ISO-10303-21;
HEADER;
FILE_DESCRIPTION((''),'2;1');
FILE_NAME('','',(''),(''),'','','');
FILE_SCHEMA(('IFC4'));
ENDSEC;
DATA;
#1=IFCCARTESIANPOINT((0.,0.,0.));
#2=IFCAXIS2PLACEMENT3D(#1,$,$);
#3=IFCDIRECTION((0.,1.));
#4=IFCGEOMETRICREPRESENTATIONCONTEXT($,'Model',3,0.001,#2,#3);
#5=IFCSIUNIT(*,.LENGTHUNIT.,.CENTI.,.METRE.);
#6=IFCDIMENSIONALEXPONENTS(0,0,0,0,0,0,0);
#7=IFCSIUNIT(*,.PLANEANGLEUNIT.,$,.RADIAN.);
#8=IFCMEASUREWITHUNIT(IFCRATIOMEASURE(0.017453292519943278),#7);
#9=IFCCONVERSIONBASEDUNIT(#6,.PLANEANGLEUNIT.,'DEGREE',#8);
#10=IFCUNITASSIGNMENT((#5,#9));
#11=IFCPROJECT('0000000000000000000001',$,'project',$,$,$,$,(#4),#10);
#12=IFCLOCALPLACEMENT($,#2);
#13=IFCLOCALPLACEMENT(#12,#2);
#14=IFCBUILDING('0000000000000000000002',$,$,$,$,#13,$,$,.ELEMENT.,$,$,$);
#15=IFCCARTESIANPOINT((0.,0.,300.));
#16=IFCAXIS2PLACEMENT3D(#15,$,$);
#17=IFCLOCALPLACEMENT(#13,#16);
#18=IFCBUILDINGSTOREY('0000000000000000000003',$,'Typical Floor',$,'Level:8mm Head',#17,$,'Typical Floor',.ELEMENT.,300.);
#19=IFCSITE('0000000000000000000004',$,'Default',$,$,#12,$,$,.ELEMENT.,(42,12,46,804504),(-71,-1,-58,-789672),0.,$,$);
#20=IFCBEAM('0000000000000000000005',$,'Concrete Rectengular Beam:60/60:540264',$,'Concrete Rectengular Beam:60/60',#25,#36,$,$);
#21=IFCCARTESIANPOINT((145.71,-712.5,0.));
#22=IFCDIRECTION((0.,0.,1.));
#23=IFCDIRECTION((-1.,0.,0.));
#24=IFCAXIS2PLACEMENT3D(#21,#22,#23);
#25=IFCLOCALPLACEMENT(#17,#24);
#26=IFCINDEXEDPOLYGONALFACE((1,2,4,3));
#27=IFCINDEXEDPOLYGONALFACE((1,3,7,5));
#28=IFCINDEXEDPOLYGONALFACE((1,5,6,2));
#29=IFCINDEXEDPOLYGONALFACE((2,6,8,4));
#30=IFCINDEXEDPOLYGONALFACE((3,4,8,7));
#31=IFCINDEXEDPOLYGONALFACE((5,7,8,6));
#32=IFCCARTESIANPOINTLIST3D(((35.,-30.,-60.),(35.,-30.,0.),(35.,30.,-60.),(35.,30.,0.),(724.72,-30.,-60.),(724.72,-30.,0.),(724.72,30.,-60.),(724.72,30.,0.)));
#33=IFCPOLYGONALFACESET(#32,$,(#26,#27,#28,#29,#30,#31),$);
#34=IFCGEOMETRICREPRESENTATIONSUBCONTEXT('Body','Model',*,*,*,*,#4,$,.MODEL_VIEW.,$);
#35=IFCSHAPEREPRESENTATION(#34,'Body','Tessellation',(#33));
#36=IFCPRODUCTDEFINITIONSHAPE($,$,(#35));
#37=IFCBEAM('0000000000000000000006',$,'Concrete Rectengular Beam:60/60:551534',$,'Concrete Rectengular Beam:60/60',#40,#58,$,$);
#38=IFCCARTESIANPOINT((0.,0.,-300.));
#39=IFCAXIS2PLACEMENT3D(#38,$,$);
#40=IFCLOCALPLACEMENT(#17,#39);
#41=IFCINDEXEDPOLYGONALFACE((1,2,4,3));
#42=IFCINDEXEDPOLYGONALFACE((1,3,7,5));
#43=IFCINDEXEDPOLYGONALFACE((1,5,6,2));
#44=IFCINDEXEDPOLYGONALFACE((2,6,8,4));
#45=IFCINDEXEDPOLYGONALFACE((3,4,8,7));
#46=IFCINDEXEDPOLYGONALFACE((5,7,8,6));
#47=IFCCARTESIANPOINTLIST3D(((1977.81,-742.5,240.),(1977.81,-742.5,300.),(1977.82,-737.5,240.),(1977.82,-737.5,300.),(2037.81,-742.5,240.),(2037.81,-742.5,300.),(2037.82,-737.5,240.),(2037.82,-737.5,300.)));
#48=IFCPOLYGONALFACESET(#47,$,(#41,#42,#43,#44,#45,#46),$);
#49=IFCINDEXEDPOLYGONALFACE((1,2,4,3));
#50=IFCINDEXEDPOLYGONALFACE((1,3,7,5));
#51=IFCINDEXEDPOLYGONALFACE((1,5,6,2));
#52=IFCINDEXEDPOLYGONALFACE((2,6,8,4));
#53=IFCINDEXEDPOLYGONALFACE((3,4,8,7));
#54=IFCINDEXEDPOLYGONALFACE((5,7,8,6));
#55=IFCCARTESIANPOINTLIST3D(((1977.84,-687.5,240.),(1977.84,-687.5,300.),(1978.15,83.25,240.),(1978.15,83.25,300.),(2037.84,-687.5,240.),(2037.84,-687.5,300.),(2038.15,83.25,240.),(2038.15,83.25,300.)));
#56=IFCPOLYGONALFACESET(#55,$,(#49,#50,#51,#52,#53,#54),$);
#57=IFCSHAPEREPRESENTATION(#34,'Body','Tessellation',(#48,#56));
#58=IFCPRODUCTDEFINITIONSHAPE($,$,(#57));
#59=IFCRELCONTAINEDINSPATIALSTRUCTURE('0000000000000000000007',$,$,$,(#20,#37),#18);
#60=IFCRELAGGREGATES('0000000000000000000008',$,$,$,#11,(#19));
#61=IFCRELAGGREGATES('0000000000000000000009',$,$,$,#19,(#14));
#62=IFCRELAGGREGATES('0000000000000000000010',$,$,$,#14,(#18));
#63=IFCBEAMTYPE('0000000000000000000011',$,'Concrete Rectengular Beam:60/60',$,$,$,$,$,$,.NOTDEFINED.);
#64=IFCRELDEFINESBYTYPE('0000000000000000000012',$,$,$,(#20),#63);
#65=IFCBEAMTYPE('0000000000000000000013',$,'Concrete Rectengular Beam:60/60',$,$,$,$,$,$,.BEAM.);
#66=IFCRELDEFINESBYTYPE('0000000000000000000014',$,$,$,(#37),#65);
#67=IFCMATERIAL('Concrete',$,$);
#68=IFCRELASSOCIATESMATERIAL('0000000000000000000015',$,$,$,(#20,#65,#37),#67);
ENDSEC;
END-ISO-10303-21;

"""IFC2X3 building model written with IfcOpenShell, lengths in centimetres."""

from ifc_helpers import new_model, entity, si_unit, converted_unit, direction, frame, frame_2d, origin, place, context, subcontext, project, spatial, rectangle, extrude, clip, halfspace, source, transform, mapped, material, type_object, type_shapes, element, save


model = new_model("IFC2X3")

# Units and contexts
model_context = context("Model", 3, precision=0.001, world=origin(), true_north=direction((0.0, 1.0)))
body_context = subcontext(model_context, "Body", "Model", "MODEL_VIEW")
ifc_project = project(units=[si_unit("LENGTHUNIT", "METRE", prefix="CENTI"), converted_unit("PLANEANGLEUNIT", "DEGREE", entity("IfcRatioMeasure", 0.017453292519943278), si_unit("PLANEANGLEUNIT", "RADIAN"), dimensions=[0, 0, 0, 0, 0, 0, 0])], contexts=[model_context])

# Site, building, storey
site_placement = place(None, origin())
site = spatial("IfcSite", under=ifc_project, at=site_placement, Name="Default", CompositionType="ELEMENT", RefLatitude=(42, 12, 46, 804504), RefLongitude=(-71, -1, -58, -789672), RefElevation=0.0)
building_placement = place(site_placement, origin())
building = spatial("IfcBuilding", under=site, at=building_placement, CompositionType="ELEMENT")
storey_placement = place(building_placement, frame((0.0, 0.0, 300.0)))
storey = spatial("IfcBuildingStorey", under=building, at=storey_placement, Name="Typical Floor", ObjectType="Level:8mm Head", LongName="Typical Floor", CompositionType="ELEMENT", Elevation=300.0)

# Beams
ifc_material = material(Name="Concrete")
beam_type_1 = type_object("IfcBeamType", Name="Concrete Rectengular Beam:60/60", PredefinedType="NOTDEFINED")
beam_1_placement = place(storey_placement, frame((145.71, -712.5, 0.0), z_axis=(0.0, 0.0, 1.0), x_axis=(-1.0, 0.0, 0.0)))
element("IfcBeam", 1, at=beam_1_placement, inside=storey, type_object=beam_type_1, material=ifc_material, Name="Concrete Rectengular Beam:60/60:540264", ObjectType="Concrete Rectengular Beam:60/60", context=body_context, shape_type="SweptSolid", body=[
    extrude(rectangle(XDim=60.0, YDim=60.0, at=frame_2d((0.0, 0.0), x_axis=(1.0, 0.0))), frame((35.0, 0.0, -30.0), z_axis=(1.0, 0.0, 0.0), x_axis=(0.0, 0.0, -1.0)), (0.0, 0.0, 1.0), 689.72),
])
beam_type_2 = type_object("IfcBeamType", Name="Concrete Rectengular Beam:60/60", PredefinedType="BEAM", material=ifc_material)
shared_shape = source(origin(), body_context, "Body", "SweptSolid", [
    clip(clip(extrude(rectangle(XDim=60.0, YDim=60.0, at=frame_2d((0.0, 0.0), x_axis=(0.0, 1.0))), frame((2007.82, -737.49, 270.0), z_axis=(-0.000408, -1.0, 0.0), x_axis=(-1.0, 0.000408, 0.0)), (0.0, 0.0, 1.0), 5.02), halfspace(frame((2040.22, -742.5, 300.0), z_axis=(0.0, -1.0, 0.0), x_axis=(-1.0, 0.0, 0.0)), False)), halfspace(frame((1977.83, -737.5, 300.0), z_axis=(0.0, 1.0, 0.0), x_axis=(0.0, 0.0, -1.0)), False)),
    clip(clip(extrude(rectangle(XDim=60.0, YDim=60.0, at=frame_2d((0.0, 0.0), x_axis=(0.0, 1.0))), frame((2008.15, 83.26, 270.0), z_axis=(-0.000408, -1.0, 0.0), x_axis=(-1.0, 0.000408, 0.0)), (0.0, 0.0, 1.0), 770.78), halfspace(frame((2037.83, -687.5, 300.0), z_axis=(0.0, -1.0, 0.0), x_axis=(0.0, 0.0, -1.0)), False)), halfspace(frame((1976.89, 83.25, 270.0), z_axis=(0.0, 1.0, 0.0), x_axis=(0.0, 0.0, -1.0)), False)),
])
type_shapes(beam_type_2, [shared_shape])
beam_2_placement = place(storey_placement, frame((0.0, 0.0, -300.0)))
element("IfcBeam", 2, at=beam_2_placement, inside=storey, type_object=beam_type_2, material=ifc_material, Name="Concrete Rectengular Beam:60/60:551534", ObjectType="Concrete Rectengular Beam:60/60", context=body_context, shape_type="MappedRepresentation", body=[
    mapped(shared_shape, transform((0.0, 0.0, 0.0), scale=1.0)),
])

save(model, "model.ifc")
